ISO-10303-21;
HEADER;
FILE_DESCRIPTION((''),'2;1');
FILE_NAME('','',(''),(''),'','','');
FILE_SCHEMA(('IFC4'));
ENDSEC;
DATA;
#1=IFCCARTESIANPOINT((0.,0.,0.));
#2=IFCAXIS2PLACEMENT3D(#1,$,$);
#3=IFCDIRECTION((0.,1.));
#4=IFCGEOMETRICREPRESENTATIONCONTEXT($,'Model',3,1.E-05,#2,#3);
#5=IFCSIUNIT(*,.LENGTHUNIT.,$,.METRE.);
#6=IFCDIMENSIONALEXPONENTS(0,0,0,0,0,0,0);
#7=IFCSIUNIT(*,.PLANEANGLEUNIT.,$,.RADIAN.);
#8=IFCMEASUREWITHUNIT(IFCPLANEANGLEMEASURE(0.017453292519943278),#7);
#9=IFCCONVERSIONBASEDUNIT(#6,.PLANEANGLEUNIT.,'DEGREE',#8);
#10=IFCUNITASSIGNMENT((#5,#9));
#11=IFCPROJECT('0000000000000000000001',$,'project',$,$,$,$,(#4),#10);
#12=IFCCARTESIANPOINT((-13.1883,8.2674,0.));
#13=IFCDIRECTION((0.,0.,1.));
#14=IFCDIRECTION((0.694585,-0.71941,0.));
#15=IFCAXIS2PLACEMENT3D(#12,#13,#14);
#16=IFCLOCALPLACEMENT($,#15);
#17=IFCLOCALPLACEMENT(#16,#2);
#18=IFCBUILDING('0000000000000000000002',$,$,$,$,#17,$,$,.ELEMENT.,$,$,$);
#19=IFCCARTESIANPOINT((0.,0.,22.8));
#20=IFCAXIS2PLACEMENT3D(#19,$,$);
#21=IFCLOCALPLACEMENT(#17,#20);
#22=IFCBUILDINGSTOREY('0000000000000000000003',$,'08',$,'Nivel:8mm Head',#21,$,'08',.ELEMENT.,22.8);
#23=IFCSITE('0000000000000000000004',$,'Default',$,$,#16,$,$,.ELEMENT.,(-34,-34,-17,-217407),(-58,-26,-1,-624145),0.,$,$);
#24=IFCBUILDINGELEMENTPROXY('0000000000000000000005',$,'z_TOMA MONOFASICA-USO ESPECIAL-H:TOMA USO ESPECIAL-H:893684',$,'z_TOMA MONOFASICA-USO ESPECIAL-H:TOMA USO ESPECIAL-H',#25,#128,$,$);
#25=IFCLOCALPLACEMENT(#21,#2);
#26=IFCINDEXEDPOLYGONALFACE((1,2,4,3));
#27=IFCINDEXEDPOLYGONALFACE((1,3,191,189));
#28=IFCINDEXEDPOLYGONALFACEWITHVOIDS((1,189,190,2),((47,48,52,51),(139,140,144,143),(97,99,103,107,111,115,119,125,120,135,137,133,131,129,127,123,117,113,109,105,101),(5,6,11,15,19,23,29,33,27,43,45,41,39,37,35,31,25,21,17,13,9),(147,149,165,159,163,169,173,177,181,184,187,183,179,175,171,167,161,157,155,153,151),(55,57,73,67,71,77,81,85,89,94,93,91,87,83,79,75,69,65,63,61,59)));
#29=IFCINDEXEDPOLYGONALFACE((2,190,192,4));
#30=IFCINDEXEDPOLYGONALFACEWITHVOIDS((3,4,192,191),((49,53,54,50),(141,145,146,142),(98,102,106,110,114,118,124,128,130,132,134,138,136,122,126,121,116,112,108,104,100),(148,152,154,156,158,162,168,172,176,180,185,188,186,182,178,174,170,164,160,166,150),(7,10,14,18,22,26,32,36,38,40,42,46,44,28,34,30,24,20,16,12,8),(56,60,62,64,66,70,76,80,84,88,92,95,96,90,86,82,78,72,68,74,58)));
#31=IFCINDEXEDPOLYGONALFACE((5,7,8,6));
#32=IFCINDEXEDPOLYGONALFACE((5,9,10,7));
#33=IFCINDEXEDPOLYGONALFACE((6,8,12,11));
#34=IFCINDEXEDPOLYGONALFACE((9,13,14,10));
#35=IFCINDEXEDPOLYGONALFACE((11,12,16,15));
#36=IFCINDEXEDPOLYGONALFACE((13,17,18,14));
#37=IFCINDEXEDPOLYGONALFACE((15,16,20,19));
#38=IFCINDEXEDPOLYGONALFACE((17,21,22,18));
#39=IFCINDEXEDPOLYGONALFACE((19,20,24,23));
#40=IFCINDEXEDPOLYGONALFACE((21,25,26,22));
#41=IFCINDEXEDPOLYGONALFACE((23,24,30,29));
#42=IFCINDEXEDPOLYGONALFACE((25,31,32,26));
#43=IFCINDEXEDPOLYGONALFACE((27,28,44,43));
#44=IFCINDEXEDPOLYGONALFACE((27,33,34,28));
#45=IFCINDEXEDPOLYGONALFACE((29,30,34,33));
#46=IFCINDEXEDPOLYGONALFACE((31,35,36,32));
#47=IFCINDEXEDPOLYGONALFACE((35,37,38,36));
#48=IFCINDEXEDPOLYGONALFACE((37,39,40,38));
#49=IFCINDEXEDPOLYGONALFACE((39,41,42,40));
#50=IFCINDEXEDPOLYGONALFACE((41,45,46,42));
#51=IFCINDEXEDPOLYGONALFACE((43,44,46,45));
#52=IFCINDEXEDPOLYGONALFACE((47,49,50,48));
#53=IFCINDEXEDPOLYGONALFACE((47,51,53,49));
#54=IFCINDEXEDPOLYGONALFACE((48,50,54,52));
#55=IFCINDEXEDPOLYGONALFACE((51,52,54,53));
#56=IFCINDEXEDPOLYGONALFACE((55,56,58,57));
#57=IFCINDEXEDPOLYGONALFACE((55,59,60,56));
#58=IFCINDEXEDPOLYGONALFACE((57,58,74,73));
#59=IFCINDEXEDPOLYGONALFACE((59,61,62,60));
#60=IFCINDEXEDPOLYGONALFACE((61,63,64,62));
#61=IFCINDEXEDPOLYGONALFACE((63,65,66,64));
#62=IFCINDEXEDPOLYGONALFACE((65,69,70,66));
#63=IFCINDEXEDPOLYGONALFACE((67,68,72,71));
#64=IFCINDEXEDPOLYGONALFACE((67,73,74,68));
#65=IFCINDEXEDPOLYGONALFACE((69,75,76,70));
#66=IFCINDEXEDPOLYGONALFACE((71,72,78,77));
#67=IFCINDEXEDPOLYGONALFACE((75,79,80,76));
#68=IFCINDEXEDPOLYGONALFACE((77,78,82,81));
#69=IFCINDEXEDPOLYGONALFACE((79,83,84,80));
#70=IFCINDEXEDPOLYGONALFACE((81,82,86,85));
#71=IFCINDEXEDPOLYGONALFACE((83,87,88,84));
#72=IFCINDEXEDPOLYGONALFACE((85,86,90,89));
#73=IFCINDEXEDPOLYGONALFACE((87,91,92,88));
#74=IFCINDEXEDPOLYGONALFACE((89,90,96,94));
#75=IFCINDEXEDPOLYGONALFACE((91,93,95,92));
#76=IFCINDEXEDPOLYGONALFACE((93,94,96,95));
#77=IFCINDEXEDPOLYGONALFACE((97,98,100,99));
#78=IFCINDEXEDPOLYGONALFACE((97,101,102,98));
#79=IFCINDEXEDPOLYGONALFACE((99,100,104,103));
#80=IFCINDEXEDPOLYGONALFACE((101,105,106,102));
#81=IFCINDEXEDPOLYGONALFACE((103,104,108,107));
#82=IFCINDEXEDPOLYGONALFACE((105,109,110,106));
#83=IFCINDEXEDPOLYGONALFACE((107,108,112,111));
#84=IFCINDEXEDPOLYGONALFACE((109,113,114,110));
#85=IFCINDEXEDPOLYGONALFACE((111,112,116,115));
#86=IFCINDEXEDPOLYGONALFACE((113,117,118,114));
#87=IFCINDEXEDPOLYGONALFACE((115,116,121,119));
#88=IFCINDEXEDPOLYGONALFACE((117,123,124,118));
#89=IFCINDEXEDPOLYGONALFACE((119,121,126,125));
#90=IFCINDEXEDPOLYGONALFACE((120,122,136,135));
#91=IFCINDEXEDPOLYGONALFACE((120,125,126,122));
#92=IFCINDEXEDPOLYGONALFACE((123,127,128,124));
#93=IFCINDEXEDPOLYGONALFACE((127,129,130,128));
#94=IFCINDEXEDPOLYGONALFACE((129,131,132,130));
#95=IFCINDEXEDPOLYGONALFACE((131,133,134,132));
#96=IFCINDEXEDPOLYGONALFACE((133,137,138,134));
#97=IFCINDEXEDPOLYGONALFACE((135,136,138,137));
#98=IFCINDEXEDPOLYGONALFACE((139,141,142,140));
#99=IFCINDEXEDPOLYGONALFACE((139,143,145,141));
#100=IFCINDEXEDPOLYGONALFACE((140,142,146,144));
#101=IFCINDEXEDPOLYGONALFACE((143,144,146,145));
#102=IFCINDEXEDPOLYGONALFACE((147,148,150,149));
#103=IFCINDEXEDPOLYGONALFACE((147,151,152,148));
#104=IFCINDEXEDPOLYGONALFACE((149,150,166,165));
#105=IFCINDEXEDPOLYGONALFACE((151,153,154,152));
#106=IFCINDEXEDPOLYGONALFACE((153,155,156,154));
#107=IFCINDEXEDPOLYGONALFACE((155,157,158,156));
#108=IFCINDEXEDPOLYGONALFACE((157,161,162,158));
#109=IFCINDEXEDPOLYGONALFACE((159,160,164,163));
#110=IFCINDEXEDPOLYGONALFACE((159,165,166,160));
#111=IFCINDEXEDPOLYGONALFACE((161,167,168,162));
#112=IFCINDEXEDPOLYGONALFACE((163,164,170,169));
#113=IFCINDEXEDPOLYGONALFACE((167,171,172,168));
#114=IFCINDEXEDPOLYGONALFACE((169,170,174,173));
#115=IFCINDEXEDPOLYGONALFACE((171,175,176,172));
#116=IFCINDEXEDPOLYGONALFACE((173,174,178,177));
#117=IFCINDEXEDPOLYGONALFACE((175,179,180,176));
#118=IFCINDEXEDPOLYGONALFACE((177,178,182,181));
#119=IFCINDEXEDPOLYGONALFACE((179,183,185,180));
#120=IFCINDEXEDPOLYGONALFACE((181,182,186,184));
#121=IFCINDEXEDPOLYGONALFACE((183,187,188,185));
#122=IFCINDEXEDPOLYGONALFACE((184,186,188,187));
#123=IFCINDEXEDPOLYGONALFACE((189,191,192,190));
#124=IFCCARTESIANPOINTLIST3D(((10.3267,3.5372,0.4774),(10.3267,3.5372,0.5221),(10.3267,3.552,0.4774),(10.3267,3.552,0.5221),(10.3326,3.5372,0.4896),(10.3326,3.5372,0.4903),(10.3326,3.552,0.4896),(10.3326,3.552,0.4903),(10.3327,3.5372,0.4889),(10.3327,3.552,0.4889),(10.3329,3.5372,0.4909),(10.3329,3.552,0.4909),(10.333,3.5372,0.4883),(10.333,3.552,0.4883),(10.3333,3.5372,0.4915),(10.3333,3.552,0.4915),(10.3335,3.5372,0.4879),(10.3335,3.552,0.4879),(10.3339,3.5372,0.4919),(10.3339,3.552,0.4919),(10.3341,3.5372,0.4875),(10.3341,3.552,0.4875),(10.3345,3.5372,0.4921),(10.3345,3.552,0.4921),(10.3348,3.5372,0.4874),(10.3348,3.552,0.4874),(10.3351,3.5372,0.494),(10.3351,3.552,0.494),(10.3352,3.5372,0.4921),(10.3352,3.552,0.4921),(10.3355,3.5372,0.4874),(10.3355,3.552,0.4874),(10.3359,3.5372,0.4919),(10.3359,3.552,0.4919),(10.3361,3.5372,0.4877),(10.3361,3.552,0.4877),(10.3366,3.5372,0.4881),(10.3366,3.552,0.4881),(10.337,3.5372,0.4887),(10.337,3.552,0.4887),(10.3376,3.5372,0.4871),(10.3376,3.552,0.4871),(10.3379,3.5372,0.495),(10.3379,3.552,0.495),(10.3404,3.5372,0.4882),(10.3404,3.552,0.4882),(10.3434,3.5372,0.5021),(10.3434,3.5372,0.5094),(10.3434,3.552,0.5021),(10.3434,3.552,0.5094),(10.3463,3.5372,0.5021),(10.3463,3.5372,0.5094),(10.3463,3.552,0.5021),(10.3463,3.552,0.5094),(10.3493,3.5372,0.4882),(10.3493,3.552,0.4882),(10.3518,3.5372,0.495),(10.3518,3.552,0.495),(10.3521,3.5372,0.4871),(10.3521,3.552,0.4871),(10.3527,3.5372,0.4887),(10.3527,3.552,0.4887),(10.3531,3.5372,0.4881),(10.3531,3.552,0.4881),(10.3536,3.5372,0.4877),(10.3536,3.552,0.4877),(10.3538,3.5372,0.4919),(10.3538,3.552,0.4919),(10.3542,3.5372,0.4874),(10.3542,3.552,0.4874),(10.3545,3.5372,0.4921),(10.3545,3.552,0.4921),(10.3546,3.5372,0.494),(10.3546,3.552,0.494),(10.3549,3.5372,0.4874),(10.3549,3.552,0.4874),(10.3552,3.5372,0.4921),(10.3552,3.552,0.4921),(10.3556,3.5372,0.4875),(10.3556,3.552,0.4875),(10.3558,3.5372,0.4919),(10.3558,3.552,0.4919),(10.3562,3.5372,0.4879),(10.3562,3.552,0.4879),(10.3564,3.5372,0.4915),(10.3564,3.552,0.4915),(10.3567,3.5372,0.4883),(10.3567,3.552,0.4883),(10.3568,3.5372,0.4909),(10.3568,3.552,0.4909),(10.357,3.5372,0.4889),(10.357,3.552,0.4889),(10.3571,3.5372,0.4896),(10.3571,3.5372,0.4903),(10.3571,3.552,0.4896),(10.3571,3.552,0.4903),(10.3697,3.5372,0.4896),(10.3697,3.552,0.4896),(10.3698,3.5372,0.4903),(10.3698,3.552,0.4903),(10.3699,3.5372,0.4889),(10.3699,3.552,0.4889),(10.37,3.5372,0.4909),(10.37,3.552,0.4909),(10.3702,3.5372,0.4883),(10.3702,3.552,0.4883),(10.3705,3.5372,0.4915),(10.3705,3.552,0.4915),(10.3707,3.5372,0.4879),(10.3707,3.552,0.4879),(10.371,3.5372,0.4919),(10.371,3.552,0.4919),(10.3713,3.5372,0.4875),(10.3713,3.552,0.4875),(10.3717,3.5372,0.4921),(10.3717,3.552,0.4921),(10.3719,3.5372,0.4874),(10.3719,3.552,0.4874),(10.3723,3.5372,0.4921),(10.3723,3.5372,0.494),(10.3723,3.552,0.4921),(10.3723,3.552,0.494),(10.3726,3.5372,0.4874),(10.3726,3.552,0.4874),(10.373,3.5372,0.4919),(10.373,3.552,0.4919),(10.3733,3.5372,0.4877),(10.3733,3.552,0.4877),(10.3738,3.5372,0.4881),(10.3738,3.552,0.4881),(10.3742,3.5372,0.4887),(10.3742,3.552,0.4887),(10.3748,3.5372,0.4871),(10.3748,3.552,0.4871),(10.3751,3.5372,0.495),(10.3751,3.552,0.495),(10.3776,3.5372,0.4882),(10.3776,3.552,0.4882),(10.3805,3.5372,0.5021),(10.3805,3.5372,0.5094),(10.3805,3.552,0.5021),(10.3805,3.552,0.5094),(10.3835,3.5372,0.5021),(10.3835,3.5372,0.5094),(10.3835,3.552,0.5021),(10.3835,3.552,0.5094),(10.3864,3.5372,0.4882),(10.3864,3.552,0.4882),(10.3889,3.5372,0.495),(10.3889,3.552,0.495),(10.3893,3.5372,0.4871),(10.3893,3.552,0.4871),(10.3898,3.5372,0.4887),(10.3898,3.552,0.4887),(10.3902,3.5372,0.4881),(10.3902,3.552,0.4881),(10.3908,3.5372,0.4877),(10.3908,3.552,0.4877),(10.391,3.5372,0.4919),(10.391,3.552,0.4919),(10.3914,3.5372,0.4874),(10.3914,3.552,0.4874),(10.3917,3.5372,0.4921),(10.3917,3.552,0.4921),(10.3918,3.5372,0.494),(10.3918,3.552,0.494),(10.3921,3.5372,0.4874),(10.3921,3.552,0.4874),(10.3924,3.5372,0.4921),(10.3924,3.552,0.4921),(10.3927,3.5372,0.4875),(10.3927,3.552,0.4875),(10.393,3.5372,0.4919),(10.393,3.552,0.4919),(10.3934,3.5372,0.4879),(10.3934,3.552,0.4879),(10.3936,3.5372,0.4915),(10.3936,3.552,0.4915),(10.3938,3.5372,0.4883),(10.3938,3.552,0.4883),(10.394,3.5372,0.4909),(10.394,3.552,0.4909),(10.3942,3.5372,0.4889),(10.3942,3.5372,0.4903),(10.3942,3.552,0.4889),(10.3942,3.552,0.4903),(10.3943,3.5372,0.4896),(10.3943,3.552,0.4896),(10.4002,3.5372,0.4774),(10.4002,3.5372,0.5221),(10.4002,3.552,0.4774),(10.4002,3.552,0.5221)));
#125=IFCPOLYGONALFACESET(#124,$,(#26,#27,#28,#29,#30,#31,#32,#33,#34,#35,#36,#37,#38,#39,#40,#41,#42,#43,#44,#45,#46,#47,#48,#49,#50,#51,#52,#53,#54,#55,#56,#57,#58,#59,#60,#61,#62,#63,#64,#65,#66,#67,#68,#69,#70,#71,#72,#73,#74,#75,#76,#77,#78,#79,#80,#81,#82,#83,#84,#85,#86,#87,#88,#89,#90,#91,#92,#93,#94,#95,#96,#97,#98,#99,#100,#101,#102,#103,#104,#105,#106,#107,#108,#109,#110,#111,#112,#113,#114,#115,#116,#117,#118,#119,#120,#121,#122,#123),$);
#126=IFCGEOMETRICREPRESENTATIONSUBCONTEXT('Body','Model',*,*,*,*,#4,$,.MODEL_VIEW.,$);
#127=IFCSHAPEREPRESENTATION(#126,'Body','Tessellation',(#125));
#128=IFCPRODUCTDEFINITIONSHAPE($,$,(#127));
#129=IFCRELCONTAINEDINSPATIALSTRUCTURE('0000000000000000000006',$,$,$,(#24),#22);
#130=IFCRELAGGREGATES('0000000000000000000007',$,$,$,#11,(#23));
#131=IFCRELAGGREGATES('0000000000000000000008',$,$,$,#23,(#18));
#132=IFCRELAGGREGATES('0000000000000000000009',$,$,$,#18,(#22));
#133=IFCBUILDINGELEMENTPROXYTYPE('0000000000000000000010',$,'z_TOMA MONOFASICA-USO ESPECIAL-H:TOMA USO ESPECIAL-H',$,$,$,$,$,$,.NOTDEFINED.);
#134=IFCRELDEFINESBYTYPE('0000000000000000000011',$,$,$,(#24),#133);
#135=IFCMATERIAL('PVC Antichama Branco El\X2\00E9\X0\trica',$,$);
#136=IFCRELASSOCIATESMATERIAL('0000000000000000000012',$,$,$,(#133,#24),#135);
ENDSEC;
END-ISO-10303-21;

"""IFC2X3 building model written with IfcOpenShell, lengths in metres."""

from ifc_helpers import new_model, entity, si_unit, converted_unit, direction, frame, frame_2d, origin, place, context, subcontext, project, spatial, polyline, circle_curve, parameter, trimmed, segment, composite_curve, outline, extrude, source, transform, mapped, material, type_object, type_shapes, element, save


model = new_model("IFC2X3")

# Units and contexts
model_context = context("Model", 3, precision=1e-05, world=origin(), true_north=direction((0.0, 1.0)))
body_context = subcontext(model_context, "Body", "Model", "MODEL_VIEW")
ifc_project = project(units=[si_unit("LENGTHUNIT", "METRE"), converted_unit("PLANEANGLEUNIT", "DEGREE", entity("IfcPlaneAngleMeasure", 0.017453292519943278), si_unit("PLANEANGLEUNIT", "RADIAN"), dimensions=[0, 0, 0, 0, 0, 0, 0])], contexts=[model_context])

# Site, building, storey
site_placement = place(None, frame((-13.1883, 8.2674, 0.0), z_axis=(0.0, 0.0, 1.0), x_axis=(0.694585, -0.71941, 0.0)))
site = spatial("IfcSite", under=ifc_project, at=site_placement, Name="Default", CompositionType="ELEMENT", RefLatitude=(-34, -34, -17, -217407), RefLongitude=(-58, -26, -1, -624145), RefElevation=0.0)
building_placement = place(site_placement, origin())
building = spatial("IfcBuilding", under=site, at=building_placement, CompositionType="ELEMENT")
storey_placement = place(building_placement, frame((0.0, 0.0, 22.8)))
storey = spatial("IfcBuildingStorey", under=building, at=storey_placement, Name="08", ObjectType="Nivel:8mm Head", LongName="08", CompositionType="ELEMENT", Elevation=22.8)

# Building element proxy
ifc_material_1 = material(Name="PVC Antichama Branco Elétrica")
building_element_proxy_type_1 = type_object("IfcBuildingElementProxyType", Name="z_TOMA MONOFASICA-USO ESPECIAL-H:TOMA USO ESPECIAL-H", PredefinedType="NOTDEFINED", material=ifc_material_1)
shared_shape_1 = source(origin(), body_context, "Body", "SweptSolid", [
    extrude(outline(polyline([(-0.0368, -0.0223), (0.0368, -0.0223), (0.0368, 0.0223), (-0.0368, 0.0223), (-0.0368, -0.0223)]), holes=[composite_curve([segment(polyline([(0.0141, 0.0115), (0.0116, 0.0047)]), True, "CONTINUOUS"), segment(polyline([(0.0116, 0.0047), (0.0088, 0.0057)]), True, "CONTINUOUS"), segment(polyline([(0.0088, 0.0057), (0.0096, 0.0078)]), True, "CONTINUOUS"), segment(trimmed(circle_curve(frame_2d((0.0087, 0.0099), x_axis=(1.0, 0.0)), 0.0024), [parameter(27.118901)], [parameter(292.881099)], True, "PARAMETER"), False, "CONTINUOUS"), segment(polyline([(0.0108, 0.011), (0.0113, 0.0126)]), True, "CONTINUOUS"), segment(polyline([(0.0113, 0.0126), (0.0141, 0.0115)]), True, "CONTINUOUS")], self_intersect=False), composite_curve([segment(polyline([(0.0255, 0.0047), (0.023, 0.0115)]), True, "CONTINUOUS"), segment(polyline([(0.023, 0.0115), (0.0258, 0.0126)]), True, "CONTINUOUS"), segment(polyline([(0.0258, 0.0126), (0.0264, 0.011)]), True, "CONTINUOUS"), segment(trimmed(circle_curve(frame_2d((0.0285, 0.0099), x_axis=(1.0, 0.0)), 0.0024), [parameter(247.118901)], [parameter(152.881099)], True, "PARAMETER"), False, "CONTINUOUS"), segment(polyline([(0.0276, 0.0078), (0.0283, 0.0057)]), True, "CONTINUOUS"), segment(polyline([(0.0283, 0.0057), (0.0255, 0.0047)]), True, "CONTINUOUS")], self_intersect=False), polyline([(0.0201, -0.0024), (0.0201, -0.0097), (0.0171, -0.0097), (0.0171, -0.0024), (0.0201, -0.0024)]), composite_curve([segment(polyline([(-0.0141, 0.0115), (-0.0113, 0.0126)]), True, "CONTINUOUS"), segment(polyline([(-0.0113, 0.0126), (-0.0108, 0.011)]), True, "CONTINUOUS"), segment(trimmed(circle_curve(frame_2d((-0.0087, 0.0099), x_axis=(1.0, 0.0)), 0.0024), [parameter(247.118901)], [parameter(152.881099)], True, "PARAMETER"), False, "CONTINUOUS"), segment(polyline([(-0.0096, 0.0078), (-0.0088, 0.0057)]), True, "CONTINUOUS"), segment(polyline([(-0.0088, 0.0057), (-0.0116, 0.0047)]), True, "CONTINUOUS"), segment(polyline([(-0.0116, 0.0047), (-0.0141, 0.0115)]), True, "CONTINUOUS")], self_intersect=False), composite_curve([segment(polyline([(-0.0255, 0.0047), (-0.0283, 0.0057)]), True, "CONTINUOUS"), segment(polyline([(-0.0283, 0.0057), (-0.0276, 0.0078)]), True, "CONTINUOUS"), segment(trimmed(circle_curve(frame_2d((-0.0285, 0.0099), x_axis=(1.0, 0.0)), 0.0024), [parameter(27.118901)], [parameter(292.881099)], True, "PARAMETER"), False, "CONTINUOUS"), segment(polyline([(-0.0264, 0.011), (-0.0258, 0.0126)]), True, "CONTINUOUS"), segment(polyline([(-0.0258, 0.0126), (-0.023, 0.0115)]), True, "CONTINUOUS"), segment(polyline([(-0.023, 0.0115), (-0.0255, 0.0047)]), True, "CONTINUOUS")], self_intersect=False), polyline([(-0.0201, -0.0024), (-0.0171, -0.0024), (-0.0171, -0.0097), (-0.0201, -0.0097), (-0.0201, -0.0024)])]), frame((0.0, -0.005, 0.0223), z_axis=(0.0, 1.0, 0.0), x_axis=(1.0, 0.0, 0.0)), (0.0, 0.0, 1.0), 0.0148),
])
type_shapes(building_element_proxy_type_1, [shared_shape_1])
for number, where, z_axis, x_axis, name in (
    (1, (10.3634, 3.547, 0.4774), (0.0, 0.0, 1.0), (-1.0, 0.0, 0.0), "z_TOMA MONOFASICA-USO ESPECIAL-H:TOMA USO ESPECIAL-H:893684"),
):
    element("IfcBuildingElementProxy", number, at=place(storey_placement, frame(where, z_axis=z_axis, x_axis=x_axis)), inside=storey, type_object=building_element_proxy_type_1, material=ifc_material_1, Name=name, ObjectType="z_TOMA MONOFASICA-USO ESPECIAL-H:TOMA USO ESPECIAL-H", context=body_context, shape_type="MappedRepresentation", body=[
        mapped(shared_shape_1, transform((0.0, 0.0, 0.0), scale=1.0)),
    ])

save(model, "model.ifc")
